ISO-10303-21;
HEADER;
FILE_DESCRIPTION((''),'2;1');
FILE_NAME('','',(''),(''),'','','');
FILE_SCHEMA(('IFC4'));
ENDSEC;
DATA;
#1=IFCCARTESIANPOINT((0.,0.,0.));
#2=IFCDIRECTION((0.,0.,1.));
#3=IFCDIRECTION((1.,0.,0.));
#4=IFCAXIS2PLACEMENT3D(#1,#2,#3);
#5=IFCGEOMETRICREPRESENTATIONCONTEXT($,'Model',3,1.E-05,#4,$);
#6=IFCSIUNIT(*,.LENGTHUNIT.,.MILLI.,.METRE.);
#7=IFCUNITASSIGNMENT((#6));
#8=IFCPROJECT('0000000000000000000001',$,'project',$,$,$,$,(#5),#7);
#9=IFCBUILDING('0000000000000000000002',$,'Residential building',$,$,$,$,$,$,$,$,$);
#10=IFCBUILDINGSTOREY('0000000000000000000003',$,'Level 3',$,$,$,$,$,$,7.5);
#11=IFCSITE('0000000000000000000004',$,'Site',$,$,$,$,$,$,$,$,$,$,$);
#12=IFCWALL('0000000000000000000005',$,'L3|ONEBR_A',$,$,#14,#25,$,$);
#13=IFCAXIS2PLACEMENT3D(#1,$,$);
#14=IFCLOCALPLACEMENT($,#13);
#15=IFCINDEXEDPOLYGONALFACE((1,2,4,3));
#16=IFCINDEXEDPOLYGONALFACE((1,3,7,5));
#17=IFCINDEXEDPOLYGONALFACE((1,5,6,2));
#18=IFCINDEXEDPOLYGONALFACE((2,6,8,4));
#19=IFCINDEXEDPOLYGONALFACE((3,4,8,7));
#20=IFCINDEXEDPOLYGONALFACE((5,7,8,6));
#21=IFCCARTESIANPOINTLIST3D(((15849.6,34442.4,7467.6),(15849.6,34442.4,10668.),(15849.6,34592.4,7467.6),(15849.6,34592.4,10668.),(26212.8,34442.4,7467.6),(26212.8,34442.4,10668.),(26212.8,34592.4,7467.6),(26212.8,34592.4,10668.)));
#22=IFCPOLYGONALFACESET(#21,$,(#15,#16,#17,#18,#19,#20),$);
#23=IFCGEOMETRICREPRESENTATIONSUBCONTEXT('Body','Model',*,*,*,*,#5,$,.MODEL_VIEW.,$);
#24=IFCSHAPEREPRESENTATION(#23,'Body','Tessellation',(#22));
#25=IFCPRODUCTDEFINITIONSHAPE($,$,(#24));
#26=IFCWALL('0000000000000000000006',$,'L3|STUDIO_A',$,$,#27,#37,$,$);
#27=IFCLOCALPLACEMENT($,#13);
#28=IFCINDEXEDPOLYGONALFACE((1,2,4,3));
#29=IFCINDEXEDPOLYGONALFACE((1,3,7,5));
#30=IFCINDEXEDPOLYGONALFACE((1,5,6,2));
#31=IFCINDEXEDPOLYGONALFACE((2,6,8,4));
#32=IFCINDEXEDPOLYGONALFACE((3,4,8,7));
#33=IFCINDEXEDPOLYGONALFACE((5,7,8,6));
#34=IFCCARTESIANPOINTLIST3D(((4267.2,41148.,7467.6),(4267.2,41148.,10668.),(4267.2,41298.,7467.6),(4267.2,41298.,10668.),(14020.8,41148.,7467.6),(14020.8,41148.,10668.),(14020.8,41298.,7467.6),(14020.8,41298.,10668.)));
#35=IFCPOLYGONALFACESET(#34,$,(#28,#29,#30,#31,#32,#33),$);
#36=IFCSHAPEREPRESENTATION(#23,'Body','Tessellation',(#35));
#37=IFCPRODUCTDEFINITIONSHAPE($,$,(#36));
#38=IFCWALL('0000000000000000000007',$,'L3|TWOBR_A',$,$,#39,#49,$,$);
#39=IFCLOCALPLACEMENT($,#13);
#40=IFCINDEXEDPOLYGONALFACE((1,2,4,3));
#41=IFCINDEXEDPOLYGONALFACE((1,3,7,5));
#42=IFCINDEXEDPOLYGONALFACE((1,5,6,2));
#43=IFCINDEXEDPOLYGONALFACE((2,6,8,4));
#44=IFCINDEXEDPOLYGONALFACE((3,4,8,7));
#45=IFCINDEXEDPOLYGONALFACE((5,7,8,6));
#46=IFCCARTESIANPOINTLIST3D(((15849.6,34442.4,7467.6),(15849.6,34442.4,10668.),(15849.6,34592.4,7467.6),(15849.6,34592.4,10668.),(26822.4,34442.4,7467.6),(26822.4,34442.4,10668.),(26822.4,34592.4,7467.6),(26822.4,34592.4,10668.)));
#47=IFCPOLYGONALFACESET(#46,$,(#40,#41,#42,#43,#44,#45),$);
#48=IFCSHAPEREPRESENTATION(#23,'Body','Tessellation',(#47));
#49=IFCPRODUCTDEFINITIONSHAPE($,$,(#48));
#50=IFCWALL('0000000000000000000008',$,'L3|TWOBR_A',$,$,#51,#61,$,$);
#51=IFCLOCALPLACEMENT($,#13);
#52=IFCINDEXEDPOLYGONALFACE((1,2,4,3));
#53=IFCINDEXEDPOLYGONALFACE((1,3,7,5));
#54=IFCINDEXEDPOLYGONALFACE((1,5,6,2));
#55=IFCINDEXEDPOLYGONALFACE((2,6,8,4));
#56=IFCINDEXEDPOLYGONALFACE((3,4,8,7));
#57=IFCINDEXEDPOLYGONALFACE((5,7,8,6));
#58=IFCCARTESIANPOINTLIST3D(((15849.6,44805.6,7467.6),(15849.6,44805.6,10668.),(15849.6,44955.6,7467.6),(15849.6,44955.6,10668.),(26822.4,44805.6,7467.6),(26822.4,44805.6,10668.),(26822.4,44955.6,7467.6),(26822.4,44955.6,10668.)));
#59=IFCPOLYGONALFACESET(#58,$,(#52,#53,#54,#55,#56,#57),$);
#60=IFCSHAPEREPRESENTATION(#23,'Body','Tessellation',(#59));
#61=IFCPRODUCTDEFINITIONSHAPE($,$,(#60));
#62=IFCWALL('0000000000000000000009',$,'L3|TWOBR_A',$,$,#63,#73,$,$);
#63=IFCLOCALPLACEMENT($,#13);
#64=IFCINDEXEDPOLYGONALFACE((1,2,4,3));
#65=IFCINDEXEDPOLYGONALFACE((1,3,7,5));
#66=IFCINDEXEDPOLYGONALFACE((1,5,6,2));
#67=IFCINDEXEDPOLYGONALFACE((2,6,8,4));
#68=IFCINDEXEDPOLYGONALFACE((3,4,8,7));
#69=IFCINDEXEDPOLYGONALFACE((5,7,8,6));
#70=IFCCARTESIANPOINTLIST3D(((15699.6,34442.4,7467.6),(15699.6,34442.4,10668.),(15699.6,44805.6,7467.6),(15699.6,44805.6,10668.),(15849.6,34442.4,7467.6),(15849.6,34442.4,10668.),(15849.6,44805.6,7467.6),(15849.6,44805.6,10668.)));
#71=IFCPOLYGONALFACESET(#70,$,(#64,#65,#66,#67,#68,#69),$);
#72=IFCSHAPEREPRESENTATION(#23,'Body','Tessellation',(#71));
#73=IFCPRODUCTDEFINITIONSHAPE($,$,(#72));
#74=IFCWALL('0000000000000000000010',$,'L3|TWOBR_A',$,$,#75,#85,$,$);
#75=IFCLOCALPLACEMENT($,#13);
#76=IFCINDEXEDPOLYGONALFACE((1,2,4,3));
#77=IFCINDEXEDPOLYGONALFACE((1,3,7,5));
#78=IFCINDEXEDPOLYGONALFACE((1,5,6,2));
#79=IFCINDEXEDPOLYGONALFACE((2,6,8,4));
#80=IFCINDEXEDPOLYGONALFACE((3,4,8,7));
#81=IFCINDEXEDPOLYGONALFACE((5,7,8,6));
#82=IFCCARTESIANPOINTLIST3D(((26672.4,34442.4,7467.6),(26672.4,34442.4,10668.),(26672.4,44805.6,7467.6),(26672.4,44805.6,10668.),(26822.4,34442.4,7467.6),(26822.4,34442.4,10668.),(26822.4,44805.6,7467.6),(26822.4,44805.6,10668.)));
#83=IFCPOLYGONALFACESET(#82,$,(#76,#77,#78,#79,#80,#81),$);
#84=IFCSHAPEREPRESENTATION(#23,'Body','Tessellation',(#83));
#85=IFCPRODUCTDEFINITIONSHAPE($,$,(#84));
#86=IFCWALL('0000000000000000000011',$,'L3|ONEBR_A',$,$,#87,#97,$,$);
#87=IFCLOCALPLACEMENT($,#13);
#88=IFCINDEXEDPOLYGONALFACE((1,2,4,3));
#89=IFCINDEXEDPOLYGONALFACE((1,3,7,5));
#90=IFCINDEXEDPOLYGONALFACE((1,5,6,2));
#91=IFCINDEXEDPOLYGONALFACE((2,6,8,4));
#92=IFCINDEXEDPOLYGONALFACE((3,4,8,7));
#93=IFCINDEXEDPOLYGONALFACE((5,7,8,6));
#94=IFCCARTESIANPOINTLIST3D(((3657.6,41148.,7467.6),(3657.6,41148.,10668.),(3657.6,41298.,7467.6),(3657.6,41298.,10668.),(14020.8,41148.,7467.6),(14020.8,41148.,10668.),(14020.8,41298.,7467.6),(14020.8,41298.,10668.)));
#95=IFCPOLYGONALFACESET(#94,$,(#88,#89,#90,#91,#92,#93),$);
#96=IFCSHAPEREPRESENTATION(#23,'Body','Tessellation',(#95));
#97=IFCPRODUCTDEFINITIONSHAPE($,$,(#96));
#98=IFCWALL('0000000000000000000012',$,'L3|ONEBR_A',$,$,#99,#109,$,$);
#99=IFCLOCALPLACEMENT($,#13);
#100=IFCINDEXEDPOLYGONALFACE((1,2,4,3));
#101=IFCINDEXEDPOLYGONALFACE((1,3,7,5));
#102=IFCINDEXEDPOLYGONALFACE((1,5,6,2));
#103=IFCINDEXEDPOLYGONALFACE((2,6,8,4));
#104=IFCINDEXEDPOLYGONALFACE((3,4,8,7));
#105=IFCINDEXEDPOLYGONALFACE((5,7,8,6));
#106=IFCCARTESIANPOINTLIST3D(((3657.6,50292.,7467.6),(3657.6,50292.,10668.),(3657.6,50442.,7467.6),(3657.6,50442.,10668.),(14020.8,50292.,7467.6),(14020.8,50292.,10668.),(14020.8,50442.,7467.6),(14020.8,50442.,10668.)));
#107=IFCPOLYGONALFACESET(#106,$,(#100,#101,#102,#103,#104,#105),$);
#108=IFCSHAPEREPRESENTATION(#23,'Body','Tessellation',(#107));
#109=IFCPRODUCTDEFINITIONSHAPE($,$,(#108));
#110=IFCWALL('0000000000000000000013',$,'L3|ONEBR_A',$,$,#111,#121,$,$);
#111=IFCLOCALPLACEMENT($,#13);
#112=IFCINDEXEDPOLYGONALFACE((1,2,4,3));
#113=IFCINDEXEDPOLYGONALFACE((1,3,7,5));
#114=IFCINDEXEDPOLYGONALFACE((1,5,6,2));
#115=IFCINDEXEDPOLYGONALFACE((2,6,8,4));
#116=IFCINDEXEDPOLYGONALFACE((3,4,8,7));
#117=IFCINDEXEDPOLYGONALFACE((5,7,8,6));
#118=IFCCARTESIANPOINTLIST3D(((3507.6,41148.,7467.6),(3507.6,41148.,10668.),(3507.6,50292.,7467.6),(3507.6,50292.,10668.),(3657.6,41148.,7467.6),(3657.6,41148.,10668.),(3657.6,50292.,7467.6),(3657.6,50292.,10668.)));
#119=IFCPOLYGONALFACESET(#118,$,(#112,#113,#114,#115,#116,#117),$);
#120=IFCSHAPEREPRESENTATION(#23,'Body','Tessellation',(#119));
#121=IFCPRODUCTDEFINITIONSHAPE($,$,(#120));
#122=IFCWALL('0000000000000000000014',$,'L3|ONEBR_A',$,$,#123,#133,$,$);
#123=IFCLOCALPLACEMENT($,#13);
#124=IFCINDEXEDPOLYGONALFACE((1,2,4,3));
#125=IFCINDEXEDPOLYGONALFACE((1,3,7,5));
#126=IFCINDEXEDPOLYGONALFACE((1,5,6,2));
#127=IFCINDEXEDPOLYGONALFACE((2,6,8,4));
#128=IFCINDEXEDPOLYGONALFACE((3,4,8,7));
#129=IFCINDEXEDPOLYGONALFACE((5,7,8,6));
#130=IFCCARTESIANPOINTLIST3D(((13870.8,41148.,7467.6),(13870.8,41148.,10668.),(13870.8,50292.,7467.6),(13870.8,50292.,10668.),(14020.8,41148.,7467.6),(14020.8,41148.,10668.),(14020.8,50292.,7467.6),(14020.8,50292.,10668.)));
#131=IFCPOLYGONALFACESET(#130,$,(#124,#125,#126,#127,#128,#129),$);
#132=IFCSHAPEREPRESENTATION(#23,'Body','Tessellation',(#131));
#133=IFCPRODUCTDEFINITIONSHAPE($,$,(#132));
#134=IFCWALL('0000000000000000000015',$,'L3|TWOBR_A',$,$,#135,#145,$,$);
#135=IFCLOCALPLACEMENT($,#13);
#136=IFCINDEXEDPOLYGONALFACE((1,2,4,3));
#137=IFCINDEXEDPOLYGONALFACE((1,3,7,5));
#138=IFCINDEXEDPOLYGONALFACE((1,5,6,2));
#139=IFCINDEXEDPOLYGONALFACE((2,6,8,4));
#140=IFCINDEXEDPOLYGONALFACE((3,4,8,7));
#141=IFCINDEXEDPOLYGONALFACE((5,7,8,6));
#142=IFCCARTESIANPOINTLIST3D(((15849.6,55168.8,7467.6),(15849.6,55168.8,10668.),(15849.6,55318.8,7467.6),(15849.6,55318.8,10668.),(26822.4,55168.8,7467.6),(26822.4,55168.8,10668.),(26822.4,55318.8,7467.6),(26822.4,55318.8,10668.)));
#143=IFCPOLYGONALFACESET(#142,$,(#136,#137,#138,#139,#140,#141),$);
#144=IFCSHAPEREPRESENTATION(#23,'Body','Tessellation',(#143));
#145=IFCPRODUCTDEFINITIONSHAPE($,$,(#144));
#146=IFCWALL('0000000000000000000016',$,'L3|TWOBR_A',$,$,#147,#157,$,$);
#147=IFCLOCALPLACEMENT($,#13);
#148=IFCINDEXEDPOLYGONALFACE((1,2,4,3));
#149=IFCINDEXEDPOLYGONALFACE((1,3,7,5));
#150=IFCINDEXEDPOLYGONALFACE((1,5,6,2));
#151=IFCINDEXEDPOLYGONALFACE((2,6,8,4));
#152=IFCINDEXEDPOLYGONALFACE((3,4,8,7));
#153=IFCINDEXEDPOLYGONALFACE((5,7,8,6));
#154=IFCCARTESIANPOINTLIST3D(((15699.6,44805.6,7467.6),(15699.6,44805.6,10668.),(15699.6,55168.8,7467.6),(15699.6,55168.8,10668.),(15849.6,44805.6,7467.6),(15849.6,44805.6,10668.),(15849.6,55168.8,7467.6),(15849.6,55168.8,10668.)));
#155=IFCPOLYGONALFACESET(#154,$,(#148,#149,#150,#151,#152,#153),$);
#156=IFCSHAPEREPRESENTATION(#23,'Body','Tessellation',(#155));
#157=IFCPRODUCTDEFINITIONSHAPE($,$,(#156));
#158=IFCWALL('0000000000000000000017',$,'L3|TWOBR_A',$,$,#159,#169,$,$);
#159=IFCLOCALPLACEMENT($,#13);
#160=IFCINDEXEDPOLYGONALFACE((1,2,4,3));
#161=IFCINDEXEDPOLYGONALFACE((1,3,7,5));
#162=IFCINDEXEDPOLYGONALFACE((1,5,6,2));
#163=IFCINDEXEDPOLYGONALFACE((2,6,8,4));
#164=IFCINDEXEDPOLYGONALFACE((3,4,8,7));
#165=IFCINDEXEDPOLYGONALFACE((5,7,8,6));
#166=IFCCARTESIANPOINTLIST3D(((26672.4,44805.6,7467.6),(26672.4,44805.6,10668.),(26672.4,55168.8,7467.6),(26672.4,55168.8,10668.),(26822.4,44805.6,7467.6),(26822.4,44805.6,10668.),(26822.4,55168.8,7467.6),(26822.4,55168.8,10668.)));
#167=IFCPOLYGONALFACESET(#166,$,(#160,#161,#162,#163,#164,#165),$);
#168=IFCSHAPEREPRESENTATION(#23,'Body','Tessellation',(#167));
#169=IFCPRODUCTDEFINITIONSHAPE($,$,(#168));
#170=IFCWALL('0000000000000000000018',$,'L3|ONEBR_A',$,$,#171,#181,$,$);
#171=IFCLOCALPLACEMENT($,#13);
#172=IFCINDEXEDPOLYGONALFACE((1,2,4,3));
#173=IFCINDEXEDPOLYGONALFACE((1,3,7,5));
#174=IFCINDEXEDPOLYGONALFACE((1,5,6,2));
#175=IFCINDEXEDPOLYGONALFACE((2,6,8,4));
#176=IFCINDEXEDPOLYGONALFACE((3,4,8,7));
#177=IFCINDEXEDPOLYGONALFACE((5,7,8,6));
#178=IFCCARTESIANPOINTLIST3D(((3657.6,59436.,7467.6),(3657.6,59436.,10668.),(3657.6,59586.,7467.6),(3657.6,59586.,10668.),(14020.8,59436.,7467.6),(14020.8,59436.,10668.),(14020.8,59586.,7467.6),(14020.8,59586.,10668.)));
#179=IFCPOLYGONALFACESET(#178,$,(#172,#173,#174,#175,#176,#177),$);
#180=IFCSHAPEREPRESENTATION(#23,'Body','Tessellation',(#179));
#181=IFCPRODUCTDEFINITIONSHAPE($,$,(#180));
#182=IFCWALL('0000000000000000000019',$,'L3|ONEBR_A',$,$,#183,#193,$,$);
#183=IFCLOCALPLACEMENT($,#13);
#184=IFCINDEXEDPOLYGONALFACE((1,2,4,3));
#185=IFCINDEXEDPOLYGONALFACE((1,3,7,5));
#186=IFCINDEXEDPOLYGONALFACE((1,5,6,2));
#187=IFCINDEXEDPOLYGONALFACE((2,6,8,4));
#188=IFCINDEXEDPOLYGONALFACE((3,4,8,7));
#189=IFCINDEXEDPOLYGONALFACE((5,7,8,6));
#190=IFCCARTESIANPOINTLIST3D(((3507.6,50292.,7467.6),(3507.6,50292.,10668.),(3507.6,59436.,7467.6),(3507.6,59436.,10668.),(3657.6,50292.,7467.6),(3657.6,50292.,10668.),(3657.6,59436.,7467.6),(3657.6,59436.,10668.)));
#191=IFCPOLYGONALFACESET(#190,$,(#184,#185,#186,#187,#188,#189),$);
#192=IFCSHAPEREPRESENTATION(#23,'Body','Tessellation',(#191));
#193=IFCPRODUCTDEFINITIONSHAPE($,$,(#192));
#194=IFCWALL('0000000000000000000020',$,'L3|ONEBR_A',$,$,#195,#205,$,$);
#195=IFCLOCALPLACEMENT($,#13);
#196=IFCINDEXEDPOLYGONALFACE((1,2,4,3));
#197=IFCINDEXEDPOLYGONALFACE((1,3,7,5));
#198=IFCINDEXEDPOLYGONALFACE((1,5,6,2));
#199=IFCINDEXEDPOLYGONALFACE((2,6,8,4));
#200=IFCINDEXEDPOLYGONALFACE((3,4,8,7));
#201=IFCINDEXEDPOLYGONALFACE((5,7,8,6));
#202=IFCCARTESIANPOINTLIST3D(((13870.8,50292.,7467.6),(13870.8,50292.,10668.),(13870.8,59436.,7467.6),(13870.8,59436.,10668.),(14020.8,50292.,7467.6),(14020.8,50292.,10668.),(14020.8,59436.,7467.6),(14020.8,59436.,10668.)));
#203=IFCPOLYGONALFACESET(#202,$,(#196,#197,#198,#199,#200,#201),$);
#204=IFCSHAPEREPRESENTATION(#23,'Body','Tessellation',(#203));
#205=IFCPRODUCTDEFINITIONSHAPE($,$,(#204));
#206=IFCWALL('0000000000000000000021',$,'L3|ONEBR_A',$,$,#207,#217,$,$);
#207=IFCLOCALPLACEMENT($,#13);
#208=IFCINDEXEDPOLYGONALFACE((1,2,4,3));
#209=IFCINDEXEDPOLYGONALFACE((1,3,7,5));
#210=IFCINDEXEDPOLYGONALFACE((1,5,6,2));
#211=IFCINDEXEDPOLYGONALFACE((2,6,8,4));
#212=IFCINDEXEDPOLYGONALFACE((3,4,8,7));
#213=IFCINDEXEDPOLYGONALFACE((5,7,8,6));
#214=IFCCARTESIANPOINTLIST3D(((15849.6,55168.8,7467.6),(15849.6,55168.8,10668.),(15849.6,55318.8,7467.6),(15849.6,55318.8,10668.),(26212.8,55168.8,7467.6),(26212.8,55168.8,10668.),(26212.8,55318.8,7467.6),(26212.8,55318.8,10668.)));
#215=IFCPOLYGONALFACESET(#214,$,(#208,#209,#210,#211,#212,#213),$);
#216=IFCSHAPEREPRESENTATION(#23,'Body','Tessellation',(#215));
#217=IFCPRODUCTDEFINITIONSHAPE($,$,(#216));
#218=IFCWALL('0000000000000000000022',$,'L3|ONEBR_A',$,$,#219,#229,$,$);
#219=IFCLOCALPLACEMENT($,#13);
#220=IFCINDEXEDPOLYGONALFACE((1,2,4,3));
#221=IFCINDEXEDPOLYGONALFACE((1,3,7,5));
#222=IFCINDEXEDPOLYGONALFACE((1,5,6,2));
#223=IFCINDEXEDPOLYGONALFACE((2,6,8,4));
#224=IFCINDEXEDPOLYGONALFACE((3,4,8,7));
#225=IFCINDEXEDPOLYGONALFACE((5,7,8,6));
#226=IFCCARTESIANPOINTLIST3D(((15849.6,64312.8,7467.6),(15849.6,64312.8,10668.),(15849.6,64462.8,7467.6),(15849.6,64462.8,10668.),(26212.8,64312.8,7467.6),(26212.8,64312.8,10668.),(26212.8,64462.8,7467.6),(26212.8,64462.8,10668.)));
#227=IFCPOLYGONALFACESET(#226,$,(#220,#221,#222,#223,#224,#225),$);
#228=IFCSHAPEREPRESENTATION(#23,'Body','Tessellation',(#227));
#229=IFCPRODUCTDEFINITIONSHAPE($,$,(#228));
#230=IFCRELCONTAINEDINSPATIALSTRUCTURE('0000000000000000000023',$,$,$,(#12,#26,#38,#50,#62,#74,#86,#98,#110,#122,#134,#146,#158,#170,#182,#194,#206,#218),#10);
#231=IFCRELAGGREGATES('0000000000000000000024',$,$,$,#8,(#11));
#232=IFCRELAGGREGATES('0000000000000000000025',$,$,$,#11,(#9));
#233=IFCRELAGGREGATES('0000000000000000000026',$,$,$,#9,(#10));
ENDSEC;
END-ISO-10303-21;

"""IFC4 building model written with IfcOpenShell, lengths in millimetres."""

from ifc_helpers import new_model, si_unit, frame, origin_with_axes, place, context, subcontext, project, spatial, indexed_curve, outline, extrude, element, save


model = new_model("IFC4")

# Units and contexts
model_context = context("Model", 3, precision=1e-05, world=origin_with_axes())
body_context = subcontext(model_context, "Body", "Model", "MODEL_VIEW")
ifc_project = project(units=[si_unit("LENGTHUNIT", "METRE", prefix="MILLI")], contexts=[model_context])

# Site, building, storey
site = spatial("IfcSite", under=ifc_project, Name="Site")
building = spatial("IfcBuilding", under=site, Name="Residential building")
storey = spatial("IfcBuildingStorey", under=building, Name="Level 3", Elevation=7.5)

# Walls
wall_1_placement = place(None, frame((15849.6, 34442.4, 7467.6), z_axis=(0.0, 0.0, 1.0), x_axis=(1.0, 0.0, 0.0)))
element("IfcWall", 1, at=wall_1_placement, inside=storey, Name="L3|ONEBR_A", context=body_context, shape_type="SweptSolid", body=[
    extrude(outline(indexed_curve([(0.0, 0.0), (0.0, 150.0), (10363.2, 150.0), (10363.2, 0.0), (0.0, 0.0)], self_intersect=False)), origin_with_axes(), (0.0, 0.0, 1.0), 3200.4),
])
wall_2_placement = place(None, frame((4267.2, 41148.0, 7467.6), z_axis=(0.0, 0.0, 1.0), x_axis=(1.0, 0.0, 0.0)))
element("IfcWall", 2, at=wall_2_placement, inside=storey, Name="L3|STUDIO_A", context=body_context, shape_type="SweptSolid", body=[
    extrude(outline(indexed_curve([(0.0, 0.0), (0.0, 150.0), (9753.6, 150.0), (9753.6, 0.0), (0.0, 0.0)], self_intersect=False)), origin_with_axes(), (0.0, 0.0, 1.0), 3200.4),
])
for number, where, z_axis, x_axis, name in (
    (3, (15849.6, 34442.4, 7467.6), (0.0, 0.0, 1.0), (1.0, 0.0, 0.0), "L3|TWOBR_A"),
    (4, (15849.6, 44805.6, 7467.6), (0.0, 0.0, 1.0), (1.0, 0.0, 0.0), "L3|TWOBR_A"),
):
    element("IfcWall", number, at=place(None, frame(where, z_axis=z_axis, x_axis=x_axis)), inside=storey, Name=name, context=body_context, shape_type="SweptSolid", body=[
        extrude(outline(indexed_curve([(0.0, 0.0), (0.0, 150.0), (10972.8, 150.0), (10972.8, 0.0), (0.0, 0.0)], self_intersect=False)), origin_with_axes(), (0.0, 0.0, 1.0), 3200.4),
    ])
for number, where, z_axis, x_axis, name in (
    (5, (15849.6, 34442.4, 7467.6), (0.0, 0.0, 1.0), (0.0, 1.0, 0.0), "L3|TWOBR_A"),
    (6, (26822.4, 34442.4, 7467.6), (0.0, 0.0, 1.0), (0.0, 1.0, 0.0), "L3|TWOBR_A"),
    (7, (3657.6, 41148.0, 7467.6), (0.0, 0.0, 1.0), (1.0, 0.0, 0.0), "L3|ONEBR_A"),
    (8, (3657.6, 50292.0, 7467.6), (0.0, 0.0, 1.0), (1.0, 0.0, 0.0), "L3|ONEBR_A"),
):
    element("IfcWall", number, at=place(None, frame(where, z_axis=z_axis, x_axis=x_axis)), inside=storey, Name=name, context=body_context, shape_type="SweptSolid", body=[
        extrude(outline(indexed_curve([(0.0, 0.0), (0.0, 150.0), (10363.2, 150.0), (10363.2, 0.0), (0.0, 0.0)], self_intersect=False)), origin_with_axes(), (0.0, 0.0, 1.0), 3200.4),
    ])
for number, where, z_axis, x_axis, name in (
    (9, (3657.6, 41148.0, 7467.6), (0.0, 0.0, 1.0), (0.0, 1.0, 0.0), "L3|ONEBR_A"),
    (10, (14020.8, 41148.0, 7467.6), (0.0, 0.0, 1.0), (0.0, 1.0, 0.0), "L3|ONEBR_A"),
):
    element("IfcWall", number, at=place(None, frame(where, z_axis=z_axis, x_axis=x_axis)), inside=storey, Name=name, context=body_context, shape_type="SweptSolid", body=[
        extrude(outline(indexed_curve([(0.0, 0.0), (0.0, 150.0), (9144.0, 150.0), (9144.0, 0.0), (0.0, 0.0)], self_intersect=False)), origin_with_axes(), (0.0, 0.0, 1.0), 3200.4),
    ])
for number, where, z_axis, x_axis, name in (
    (11, (15849.6, 55168.8, 7467.6), (0.0, 0.0, 1.0), (1.0, 0.0, 0.0), "L3|TWOBR_A"),
):
    element("IfcWall", number, at=place(None, frame(where, z_axis=z_axis, x_axis=x_axis)), inside=storey, Name=name, context=body_context, shape_type="SweptSolid", body=[
        extrude(outline(indexed_curve([(0.0, 0.0), (0.0, 150.0), (10972.8, 150.0), (10972.8, 0.0), (0.0, 0.0)], self_intersect=False)), origin_with_axes(), (0.0, 0.0, 1.0), 3200.4),
    ])
for number, where, z_axis, x_axis, name in (
    (12, (15849.6, 44805.6, 7467.6), (0.0, 0.0, 1.0), (0.0, 1.0, 0.0), "L3|TWOBR_A"),
    (13, (26822.4, 44805.6, 7467.6), (0.0, 0.0, 1.0), (0.0, 1.0, 0.0), "L3|TWOBR_A"),
    (14, (3657.6, 59436.0, 7467.6), (0.0, 0.0, 1.0), (1.0, 0.0, 0.0), "L3|ONEBR_A"),
):
    element("IfcWall", number, at=place(None, frame(where, z_axis=z_axis, x_axis=x_axis)), inside=storey, Name=name, context=body_context, shape_type="SweptSolid", body=[
        extrude(outline(indexed_curve([(0.0, 0.0), (0.0, 150.0), (10363.2, 150.0), (10363.2, 0.0), (0.0, 0.0)], self_intersect=False)), origin_with_axes(), (0.0, 0.0, 1.0), 3200.4),
    ])
for number, where, z_axis, x_axis, name in (
    (15, (3657.6, 50292.0, 7467.6), (0.0, 0.0, 1.0), (0.0, 1.0, 0.0), "L3|ONEBR_A"),
    (16, (14020.8, 50292.0, 7467.6), (0.0, 0.0, 1.0), (0.0, 1.0, 0.0), "L3|ONEBR_A"),
):
    element("IfcWall", number, at=place(None, frame(where, z_axis=z_axis, x_axis=x_axis)), inside=storey, Name=name, context=body_context, shape_type="SweptSolid", body=[
        extrude(outline(indexed_curve([(0.0, 0.0), (0.0, 150.0), (9144.0, 150.0), (9144.0, 0.0), (0.0, 0.0)], self_intersect=False)), origin_with_axes(), (0.0, 0.0, 1.0), 3200.4),
    ])
for number, where, z_axis, x_axis, name in (
    (17, (15849.6, 55168.8, 7467.6), (0.0, 0.0, 1.0), (1.0, 0.0, 0.0), "L3|ONEBR_A"),
    (18, (15849.6, 64312.8, 7467.6), (0.0, 0.0, 1.0), (1.0, 0.0, 0.0), "L3|ONEBR_A"),
):
    element("IfcWall", number, at=place(None, frame(where, z_axis=z_axis, x_axis=x_axis)), inside=storey, Name=name, context=body_context, shape_type="SweptSolid", body=[
        extrude(outline(indexed_curve([(0.0, 0.0), (0.0, 150.0), (10363.2, 150.0), (10363.2, 0.0), (0.0, 0.0)], self_intersect=False)), origin_with_axes(), (0.0, 0.0, 1.0), 3200.4),
    ])

save(model, "model.ifc")
